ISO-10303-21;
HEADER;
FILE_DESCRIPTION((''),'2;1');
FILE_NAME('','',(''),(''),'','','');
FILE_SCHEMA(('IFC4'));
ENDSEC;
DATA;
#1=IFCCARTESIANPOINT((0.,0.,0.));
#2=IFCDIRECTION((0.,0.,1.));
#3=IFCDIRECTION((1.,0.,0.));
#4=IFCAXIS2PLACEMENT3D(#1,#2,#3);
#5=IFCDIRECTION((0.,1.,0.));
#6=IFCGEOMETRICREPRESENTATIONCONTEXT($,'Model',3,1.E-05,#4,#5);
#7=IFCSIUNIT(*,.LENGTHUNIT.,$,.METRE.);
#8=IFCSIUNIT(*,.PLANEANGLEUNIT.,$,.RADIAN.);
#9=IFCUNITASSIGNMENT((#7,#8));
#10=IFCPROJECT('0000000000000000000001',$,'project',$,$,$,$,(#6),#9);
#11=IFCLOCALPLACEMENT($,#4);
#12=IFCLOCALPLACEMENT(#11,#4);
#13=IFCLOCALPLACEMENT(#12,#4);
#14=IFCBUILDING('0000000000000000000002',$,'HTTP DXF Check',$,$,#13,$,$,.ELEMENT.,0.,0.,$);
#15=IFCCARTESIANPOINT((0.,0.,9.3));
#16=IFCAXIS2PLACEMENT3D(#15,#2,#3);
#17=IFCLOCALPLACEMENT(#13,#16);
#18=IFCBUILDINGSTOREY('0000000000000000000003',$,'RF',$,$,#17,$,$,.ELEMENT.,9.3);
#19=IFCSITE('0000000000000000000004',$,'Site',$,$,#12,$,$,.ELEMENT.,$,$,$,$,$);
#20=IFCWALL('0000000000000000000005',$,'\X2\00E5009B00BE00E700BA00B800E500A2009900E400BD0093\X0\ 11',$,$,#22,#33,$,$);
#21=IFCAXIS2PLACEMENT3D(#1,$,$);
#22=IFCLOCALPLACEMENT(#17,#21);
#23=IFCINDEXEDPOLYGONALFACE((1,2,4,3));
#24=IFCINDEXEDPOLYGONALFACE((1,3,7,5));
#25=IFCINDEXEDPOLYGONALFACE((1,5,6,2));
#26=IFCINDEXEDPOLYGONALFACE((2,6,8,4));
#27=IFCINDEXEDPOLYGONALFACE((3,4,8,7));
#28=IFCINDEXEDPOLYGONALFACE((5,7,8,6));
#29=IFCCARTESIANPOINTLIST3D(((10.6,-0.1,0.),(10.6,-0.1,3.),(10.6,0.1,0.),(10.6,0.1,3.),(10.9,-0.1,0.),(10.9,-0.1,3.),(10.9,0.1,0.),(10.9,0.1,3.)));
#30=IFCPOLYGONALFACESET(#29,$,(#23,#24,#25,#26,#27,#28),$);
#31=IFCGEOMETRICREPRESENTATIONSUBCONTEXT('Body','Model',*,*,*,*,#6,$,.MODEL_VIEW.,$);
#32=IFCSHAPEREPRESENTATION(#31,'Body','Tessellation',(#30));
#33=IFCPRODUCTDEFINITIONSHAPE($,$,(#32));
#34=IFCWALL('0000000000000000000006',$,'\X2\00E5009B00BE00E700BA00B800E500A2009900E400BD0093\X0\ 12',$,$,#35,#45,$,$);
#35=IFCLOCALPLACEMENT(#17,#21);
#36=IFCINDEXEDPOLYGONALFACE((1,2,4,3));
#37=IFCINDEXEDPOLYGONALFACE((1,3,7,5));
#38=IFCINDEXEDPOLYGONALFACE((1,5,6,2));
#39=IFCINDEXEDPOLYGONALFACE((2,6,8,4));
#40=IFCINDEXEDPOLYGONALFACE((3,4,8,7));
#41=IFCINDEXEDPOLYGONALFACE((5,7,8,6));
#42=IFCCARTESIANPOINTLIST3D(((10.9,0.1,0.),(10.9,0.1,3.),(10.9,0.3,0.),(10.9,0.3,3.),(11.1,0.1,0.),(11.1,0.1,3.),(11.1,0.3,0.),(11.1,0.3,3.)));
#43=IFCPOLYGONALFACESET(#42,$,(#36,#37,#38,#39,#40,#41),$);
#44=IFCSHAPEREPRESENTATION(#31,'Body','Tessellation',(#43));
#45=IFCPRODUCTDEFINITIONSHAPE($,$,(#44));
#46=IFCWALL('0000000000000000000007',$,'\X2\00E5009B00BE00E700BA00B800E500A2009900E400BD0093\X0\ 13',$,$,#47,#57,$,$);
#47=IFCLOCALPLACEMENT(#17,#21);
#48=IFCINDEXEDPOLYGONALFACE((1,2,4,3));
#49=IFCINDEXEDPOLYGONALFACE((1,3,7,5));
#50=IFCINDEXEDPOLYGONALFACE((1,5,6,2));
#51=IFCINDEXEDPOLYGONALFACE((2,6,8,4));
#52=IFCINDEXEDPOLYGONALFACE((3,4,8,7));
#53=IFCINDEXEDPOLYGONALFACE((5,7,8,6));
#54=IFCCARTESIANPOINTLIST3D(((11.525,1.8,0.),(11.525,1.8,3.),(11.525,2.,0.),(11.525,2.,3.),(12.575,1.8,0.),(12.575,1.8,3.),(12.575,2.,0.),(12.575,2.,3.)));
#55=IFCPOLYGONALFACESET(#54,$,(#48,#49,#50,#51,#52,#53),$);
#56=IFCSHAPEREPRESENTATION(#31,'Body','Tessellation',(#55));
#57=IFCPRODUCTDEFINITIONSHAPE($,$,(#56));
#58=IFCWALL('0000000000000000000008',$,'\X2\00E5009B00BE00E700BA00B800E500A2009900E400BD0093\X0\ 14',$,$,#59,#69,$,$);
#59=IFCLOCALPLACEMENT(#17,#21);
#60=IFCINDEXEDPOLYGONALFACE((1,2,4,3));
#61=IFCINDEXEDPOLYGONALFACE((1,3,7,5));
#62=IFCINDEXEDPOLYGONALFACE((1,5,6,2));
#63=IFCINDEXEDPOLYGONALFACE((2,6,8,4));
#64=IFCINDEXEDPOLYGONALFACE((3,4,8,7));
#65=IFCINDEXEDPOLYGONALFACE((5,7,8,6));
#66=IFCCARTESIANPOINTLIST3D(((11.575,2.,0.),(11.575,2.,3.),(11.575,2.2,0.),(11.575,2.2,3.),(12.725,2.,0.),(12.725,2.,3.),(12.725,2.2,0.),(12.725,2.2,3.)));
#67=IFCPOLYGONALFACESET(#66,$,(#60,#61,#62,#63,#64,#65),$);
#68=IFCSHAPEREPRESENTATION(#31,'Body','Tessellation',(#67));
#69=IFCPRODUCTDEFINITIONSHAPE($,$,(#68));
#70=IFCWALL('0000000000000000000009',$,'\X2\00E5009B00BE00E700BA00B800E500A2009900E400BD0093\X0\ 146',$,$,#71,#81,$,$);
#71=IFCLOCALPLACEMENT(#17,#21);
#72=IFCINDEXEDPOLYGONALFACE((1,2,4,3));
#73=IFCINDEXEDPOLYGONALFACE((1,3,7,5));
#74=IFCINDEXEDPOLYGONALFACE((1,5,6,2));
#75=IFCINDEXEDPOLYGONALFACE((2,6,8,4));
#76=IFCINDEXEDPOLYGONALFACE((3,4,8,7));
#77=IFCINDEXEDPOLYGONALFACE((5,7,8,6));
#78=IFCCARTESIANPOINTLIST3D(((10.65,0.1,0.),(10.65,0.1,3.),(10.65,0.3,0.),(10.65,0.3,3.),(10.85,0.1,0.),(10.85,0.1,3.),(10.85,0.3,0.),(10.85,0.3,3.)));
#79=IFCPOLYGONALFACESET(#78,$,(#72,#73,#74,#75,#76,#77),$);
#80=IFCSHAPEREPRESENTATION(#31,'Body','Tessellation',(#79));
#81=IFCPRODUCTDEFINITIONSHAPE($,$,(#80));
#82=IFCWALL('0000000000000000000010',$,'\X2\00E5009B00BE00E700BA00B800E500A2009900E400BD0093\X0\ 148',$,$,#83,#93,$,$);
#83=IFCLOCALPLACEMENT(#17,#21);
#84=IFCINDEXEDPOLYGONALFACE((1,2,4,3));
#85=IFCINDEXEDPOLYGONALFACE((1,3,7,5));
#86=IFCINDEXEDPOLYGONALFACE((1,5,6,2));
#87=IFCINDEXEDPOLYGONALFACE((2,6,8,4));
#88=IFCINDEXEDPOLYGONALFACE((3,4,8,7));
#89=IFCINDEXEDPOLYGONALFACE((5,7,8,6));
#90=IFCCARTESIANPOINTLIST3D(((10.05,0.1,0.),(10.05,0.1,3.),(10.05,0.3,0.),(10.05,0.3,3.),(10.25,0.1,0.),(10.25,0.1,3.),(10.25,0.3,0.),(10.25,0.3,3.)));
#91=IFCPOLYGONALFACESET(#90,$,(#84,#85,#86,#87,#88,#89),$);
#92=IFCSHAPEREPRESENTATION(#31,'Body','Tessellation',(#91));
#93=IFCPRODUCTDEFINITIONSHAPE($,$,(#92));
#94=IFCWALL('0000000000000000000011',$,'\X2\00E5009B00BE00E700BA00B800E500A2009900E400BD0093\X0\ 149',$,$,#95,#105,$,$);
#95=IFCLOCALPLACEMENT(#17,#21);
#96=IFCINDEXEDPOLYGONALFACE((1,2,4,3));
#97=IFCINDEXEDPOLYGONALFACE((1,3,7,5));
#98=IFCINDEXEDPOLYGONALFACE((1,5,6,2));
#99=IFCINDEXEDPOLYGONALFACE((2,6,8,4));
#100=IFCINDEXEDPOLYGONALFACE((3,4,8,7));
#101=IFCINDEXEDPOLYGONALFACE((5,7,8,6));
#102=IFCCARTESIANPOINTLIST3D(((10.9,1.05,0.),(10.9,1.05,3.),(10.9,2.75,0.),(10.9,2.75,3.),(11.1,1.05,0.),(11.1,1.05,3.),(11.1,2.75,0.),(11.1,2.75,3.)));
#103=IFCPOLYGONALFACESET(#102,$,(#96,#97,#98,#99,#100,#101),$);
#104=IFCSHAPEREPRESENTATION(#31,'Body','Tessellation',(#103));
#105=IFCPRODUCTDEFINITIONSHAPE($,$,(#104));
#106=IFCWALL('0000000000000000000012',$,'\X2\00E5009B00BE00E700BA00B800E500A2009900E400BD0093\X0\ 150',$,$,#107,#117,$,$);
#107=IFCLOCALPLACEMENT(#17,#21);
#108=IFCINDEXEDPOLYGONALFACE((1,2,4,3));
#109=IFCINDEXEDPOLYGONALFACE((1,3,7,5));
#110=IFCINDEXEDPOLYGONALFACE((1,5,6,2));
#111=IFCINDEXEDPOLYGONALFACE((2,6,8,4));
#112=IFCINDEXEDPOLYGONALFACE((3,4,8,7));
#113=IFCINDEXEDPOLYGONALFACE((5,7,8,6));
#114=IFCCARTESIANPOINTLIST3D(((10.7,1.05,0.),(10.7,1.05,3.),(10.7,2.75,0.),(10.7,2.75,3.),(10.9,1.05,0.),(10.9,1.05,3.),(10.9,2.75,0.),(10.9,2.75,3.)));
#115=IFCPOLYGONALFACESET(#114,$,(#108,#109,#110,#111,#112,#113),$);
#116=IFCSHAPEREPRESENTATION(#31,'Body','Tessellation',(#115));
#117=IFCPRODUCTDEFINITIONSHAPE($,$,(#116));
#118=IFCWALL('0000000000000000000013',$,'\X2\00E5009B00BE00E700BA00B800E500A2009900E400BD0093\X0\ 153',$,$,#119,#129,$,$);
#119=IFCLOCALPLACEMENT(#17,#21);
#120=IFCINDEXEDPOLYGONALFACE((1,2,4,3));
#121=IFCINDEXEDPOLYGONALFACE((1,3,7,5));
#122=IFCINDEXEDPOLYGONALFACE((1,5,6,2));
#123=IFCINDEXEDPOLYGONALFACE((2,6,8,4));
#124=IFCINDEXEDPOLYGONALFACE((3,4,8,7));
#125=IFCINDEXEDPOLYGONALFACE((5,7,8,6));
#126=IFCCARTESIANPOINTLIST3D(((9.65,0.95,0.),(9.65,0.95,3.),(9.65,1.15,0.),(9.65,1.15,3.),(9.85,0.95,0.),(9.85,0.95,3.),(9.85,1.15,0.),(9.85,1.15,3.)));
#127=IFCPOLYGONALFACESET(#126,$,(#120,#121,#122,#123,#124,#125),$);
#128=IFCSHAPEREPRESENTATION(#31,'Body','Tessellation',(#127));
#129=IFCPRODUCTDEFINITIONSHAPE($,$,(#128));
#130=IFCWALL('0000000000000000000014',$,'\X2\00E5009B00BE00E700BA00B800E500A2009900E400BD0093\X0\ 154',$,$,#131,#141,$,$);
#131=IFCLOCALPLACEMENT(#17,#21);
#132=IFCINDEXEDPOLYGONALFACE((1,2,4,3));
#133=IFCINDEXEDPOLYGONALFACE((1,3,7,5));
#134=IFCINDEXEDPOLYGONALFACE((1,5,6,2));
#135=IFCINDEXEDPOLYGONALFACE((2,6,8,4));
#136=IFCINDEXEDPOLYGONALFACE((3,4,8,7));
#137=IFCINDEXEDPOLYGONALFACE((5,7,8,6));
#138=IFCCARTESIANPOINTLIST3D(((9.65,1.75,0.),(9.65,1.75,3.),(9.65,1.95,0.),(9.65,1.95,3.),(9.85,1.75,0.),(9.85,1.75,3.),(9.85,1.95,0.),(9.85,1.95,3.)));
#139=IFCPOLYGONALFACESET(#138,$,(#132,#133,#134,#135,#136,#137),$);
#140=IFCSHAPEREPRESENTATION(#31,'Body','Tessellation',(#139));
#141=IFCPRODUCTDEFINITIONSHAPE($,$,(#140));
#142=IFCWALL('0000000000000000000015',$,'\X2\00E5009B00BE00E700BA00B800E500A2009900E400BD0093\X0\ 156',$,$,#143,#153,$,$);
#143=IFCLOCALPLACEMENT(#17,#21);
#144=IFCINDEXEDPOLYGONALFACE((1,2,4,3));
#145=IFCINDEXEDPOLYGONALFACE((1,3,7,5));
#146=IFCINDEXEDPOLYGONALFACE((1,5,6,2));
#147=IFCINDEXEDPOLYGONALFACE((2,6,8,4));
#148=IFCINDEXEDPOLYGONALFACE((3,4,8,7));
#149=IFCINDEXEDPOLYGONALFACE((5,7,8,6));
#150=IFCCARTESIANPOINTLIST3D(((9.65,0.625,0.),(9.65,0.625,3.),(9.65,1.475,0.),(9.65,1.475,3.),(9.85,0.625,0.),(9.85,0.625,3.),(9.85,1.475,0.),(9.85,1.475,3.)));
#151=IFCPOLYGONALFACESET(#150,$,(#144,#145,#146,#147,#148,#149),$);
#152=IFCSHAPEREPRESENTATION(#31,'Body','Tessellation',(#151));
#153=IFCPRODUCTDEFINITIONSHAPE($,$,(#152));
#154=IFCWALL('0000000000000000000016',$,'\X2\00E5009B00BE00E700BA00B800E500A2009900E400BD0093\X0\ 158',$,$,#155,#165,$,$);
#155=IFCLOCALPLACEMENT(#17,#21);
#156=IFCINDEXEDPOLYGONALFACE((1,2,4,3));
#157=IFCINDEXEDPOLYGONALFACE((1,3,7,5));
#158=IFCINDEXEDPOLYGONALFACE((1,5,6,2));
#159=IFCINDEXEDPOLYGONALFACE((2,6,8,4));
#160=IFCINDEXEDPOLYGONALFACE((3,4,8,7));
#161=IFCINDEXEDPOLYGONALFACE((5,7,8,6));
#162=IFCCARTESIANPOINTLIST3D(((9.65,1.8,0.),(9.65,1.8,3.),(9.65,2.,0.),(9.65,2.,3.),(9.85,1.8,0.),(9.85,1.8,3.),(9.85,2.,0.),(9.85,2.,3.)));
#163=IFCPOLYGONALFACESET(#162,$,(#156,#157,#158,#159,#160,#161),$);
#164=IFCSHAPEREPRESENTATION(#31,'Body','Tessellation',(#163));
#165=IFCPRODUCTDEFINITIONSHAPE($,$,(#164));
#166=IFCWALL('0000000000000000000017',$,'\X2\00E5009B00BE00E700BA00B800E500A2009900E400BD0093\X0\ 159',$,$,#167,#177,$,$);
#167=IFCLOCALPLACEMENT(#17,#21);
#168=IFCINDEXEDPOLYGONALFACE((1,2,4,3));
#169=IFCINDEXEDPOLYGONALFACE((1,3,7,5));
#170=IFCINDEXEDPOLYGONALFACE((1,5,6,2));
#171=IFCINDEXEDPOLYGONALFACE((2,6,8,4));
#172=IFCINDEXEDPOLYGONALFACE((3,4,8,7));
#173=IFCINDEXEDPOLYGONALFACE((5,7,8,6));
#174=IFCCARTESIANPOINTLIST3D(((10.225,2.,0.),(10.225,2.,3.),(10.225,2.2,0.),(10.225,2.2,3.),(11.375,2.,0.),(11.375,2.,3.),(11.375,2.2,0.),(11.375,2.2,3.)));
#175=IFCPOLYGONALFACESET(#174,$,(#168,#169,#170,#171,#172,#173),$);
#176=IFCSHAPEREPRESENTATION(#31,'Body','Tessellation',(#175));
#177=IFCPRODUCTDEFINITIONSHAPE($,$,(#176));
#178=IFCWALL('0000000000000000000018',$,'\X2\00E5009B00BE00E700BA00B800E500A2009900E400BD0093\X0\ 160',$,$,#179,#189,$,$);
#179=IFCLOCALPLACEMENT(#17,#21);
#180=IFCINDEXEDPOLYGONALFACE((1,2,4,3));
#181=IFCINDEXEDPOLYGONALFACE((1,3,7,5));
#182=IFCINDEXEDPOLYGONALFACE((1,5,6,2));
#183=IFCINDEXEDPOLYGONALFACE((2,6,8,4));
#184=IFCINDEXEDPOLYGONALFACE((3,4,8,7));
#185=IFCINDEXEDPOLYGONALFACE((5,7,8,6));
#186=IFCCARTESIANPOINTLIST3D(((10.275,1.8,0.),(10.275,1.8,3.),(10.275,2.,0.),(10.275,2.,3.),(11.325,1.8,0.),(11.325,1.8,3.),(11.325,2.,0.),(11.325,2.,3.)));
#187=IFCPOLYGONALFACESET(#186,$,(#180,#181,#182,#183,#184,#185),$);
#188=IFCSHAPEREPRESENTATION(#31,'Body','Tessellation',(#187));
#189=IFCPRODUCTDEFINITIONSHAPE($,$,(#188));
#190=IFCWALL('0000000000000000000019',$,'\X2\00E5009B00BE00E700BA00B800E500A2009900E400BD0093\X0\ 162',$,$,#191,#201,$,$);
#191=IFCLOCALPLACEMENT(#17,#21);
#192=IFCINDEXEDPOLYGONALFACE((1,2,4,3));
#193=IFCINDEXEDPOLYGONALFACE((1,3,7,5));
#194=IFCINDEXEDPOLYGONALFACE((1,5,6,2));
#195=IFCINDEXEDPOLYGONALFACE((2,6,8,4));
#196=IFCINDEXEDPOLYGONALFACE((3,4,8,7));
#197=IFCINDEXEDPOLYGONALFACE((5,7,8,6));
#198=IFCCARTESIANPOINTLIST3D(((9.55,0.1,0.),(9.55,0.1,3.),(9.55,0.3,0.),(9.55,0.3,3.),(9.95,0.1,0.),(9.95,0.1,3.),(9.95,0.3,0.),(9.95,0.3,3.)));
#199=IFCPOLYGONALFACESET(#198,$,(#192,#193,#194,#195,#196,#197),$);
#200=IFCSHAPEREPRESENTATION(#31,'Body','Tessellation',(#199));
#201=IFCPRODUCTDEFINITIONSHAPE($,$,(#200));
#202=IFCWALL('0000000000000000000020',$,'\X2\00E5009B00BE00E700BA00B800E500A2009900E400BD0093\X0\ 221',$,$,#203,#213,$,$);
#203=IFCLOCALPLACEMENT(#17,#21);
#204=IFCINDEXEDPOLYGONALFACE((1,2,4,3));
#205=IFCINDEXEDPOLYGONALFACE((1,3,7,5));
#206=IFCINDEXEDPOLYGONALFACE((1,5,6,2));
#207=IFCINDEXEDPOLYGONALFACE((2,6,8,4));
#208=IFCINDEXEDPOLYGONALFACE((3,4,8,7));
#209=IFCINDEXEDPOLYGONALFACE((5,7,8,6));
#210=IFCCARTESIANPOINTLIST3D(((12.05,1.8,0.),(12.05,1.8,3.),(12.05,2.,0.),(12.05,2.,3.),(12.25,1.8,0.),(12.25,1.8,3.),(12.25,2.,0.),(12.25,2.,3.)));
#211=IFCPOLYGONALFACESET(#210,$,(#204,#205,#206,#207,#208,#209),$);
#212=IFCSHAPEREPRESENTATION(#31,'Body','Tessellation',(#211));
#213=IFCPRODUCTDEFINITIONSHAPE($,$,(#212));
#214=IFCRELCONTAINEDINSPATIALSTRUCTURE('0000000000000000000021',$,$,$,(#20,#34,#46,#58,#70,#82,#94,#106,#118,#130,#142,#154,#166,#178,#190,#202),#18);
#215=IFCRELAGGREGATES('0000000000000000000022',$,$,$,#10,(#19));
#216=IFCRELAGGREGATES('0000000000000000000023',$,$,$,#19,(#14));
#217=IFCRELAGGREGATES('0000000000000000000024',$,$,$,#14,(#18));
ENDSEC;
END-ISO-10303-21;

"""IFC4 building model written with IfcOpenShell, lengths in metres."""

from ifc_helpers import new_model, si_unit, direction, frame, frame_2d, origin_with_axes, place, context, subcontext, project, spatial, rectangle, extrude, element, save


model = new_model("IFC4")

# Units and contexts
model_context = context("Model", 3, precision=1e-05, world=origin_with_axes(), true_north=direction((0.0, 1.0, 0.0)))
body_context = subcontext(model_context, "Body", "Model", "MODEL_VIEW")
ifc_project = project(units=[si_unit("LENGTHUNIT", "METRE"), si_unit("PLANEANGLEUNIT", "RADIAN")], contexts=[model_context])

# Site, building, storey
placement = place(None, origin_with_axes())
site_placement = place(placement, origin_with_axes())
site = spatial("IfcSite", under=ifc_project, at=site_placement, Name="Site", CompositionType="ELEMENT")
building_placement = place(site_placement, origin_with_axes())
building = spatial("IfcBuilding", under=site, at=building_placement, Name="HTTP DXF Check", CompositionType="ELEMENT", ElevationOfRefHeight=0.0, ElevationOfTerrain=0.0)
storey_placement = place(building_placement, frame((0.0, 0.0, 9.3), z_axis=(0.0, 0.0, 1.0), x_axis=(1.0, 0.0, 0.0)))
storey = spatial("IfcBuildingStorey", under=building, at=storey_placement, Name="RF", CompositionType="ELEMENT", Elevation=9.3)

# Walls
wall_1_placement = place(storey_placement, frame((10.75, 0.0, 0.0), z_axis=(0.0, 0.0, 1.0), x_axis=(1.0, 0.0, 0.0)))
element("IfcWall", 1, at=wall_1_placement, inside=storey, Name="å\u009b¾çº¸å¢\u0099ä½\u0093 11", context=body_context, shape_type="SweptSolid", body=[
    extrude(rectangle(XDim=0.3, YDim=0.2, at=frame_2d((0.0, 0.0), x_axis=(1.0, 0.0, 0.0))), frame((0.0, 0.0, 0.0), z_axis=(0.0, 0.0, 1.0)), (0.0, 0.0, 1.0), 3.0),
])
wall_2_placement = place(storey_placement, frame((11.0, 0.2, 0.0), z_axis=(0.0, 0.0, 1.0), x_axis=(1.0, 0.0, 0.0)))
element("IfcWall", 2, at=wall_2_placement, inside=storey, Name="å\u009b¾çº¸å¢\u0099ä½\u0093 12", context=body_context, shape_type="SweptSolid", body=[
    extrude(rectangle(XDim=0.2, YDim=0.2, at=frame_2d((0.0, 0.0), x_axis=(1.0, 0.0, 0.0))), frame((0.0, 0.0, 0.0), z_axis=(0.0, 0.0, 1.0)), (0.0, 0.0, 1.0), 3.0),
])
wall_3_placement = place(storey_placement, frame((12.05, 1.9, 0.0), z_axis=(0.0, 0.0, 1.0), x_axis=(-1.0, 0.0, 0.0)))
element("IfcWall", 3, at=wall_3_placement, inside=storey, Name="å\u009b¾çº¸å¢\u0099ä½\u0093 13", context=body_context, shape_type="SweptSolid", body=[
    extrude(rectangle(XDim=1.05, YDim=0.2, at=frame_2d((0.0, 0.0), x_axis=(1.0, 0.0, 0.0))), frame((0.0, 0.0, 0.0), z_axis=(0.0, 0.0, 1.0)), (0.0, 0.0, 1.0), 3.0),
])
wall_4_placement = place(storey_placement, frame((12.15, 2.1, 0.0), z_axis=(0.0, 0.0, 1.0), x_axis=(-1.0, 0.0, 0.0)))
element("IfcWall", 4, at=wall_4_placement, inside=storey, Name="å\u009b¾çº¸å¢\u0099ä½\u0093 14", context=body_context, shape_type="SweptSolid", body=[
    extrude(rectangle(XDim=1.15, YDim=0.2, at=frame_2d((0.0, 0.0), x_axis=(1.0, 0.0, 0.0))), frame((0.0, 0.0, 0.0), z_axis=(0.0, 0.0, 1.0)), (0.0, 0.0, 1.0), 3.0),
])
for number, where, z_axis, x_axis, name in (
    (5, (10.75, 0.2, 0.0), (0.0, 0.0, 1.0), (1.0, 0.0, 0.0), "å\u009b¾çº¸å¢\u0099ä½\u0093 146"),
    (6, (10.15, 0.2, 0.0), (0.0, 0.0, 1.0), (0.0, -1.0, 0.0), "å\u009b¾çº¸å¢\u0099ä½\u0093 148"),
):
    element("IfcWall", number, at=place(storey_placement, frame(where, z_axis=z_axis, x_axis=x_axis)), inside=storey, Name=name, context=body_context, shape_type="SweptSolid", body=[
        extrude(rectangle(XDim=0.2, YDim=0.2, at=frame_2d((0.0, 0.0), x_axis=(1.0, 0.0, 0.0))), frame((0.0, 0.0, 0.0), z_axis=(0.0, 0.0, 1.0)), (0.0, 0.0, 1.0), 3.0),
    ])
for number, where, z_axis, x_axis, name in (
    (7, (11.0, 1.9, 0.0), (0.0, 0.0, 1.0), (0.0, -1.0, 0.0), "å\u009b¾çº¸å¢\u0099ä½\u0093 149"),
    (8, (10.8, 1.9, 0.0), (0.0, 0.0, 1.0), (0.0, -1.0, 0.0), "å\u009b¾çº¸å¢\u0099ä½\u0093 150"),
):
    element("IfcWall", number, at=place(storey_placement, frame(where, z_axis=z_axis, x_axis=x_axis)), inside=storey, Name=name, context=body_context, shape_type="SweptSolid", body=[
        extrude(rectangle(XDim=1.7, YDim=0.2, at=frame_2d((0.0, 0.0), x_axis=(1.0, 0.0, 0.0))), frame((0.0, 0.0, 0.0), z_axis=(0.0, 0.0, 1.0)), (0.0, 0.0, 1.0), 3.0),
    ])
for number, where, z_axis, x_axis, name in (
    (9, (9.75, 1.05, 0.0), (0.0, 0.0, 1.0), (-1.0, 0.0, 0.0), "å\u009b¾çº¸å¢\u0099ä½\u0093 153"),
    (10, (9.75, 1.85, 0.0), (0.0, 0.0, 1.0), (-1.0, 0.0, 0.0), "å\u009b¾çº¸å¢\u0099ä½\u0093 154"),
):
    element("IfcWall", number, at=place(storey_placement, frame(where, z_axis=z_axis, x_axis=x_axis)), inside=storey, Name=name, context=body_context, shape_type="SweptSolid", body=[
        extrude(rectangle(XDim=0.2, YDim=0.2, at=frame_2d((0.0, 0.0), x_axis=(1.0, 0.0, 0.0))), frame((0.0, 0.0, 0.0), z_axis=(0.0, 0.0, 1.0)), (0.0, 0.0, 1.0), 3.0),
    ])
wall_5_placement = place(storey_placement, frame((9.75, 1.05, 0.0), z_axis=(0.0, 0.0, 1.0), x_axis=(0.0, -1.0, 0.0)))
element("IfcWall", 11, at=wall_5_placement, inside=storey, Name="å\u009b¾çº¸å¢\u0099ä½\u0093 156", context=body_context, shape_type="SweptSolid", body=[
    extrude(rectangle(XDim=0.85, YDim=0.2, at=frame_2d((0.0, 0.0), x_axis=(1.0, 0.0, 0.0))), frame((0.0, 0.0, 0.0), z_axis=(0.0, 0.0, 1.0)), (0.0, 0.0, 1.0), 3.0),
])
wall_6_placement = place(storey_placement, frame((9.75, 1.9, 0.0), z_axis=(0.0, 0.0, 1.0), x_axis=(0.0, -1.0, 0.0)))
element("IfcWall", 12, at=wall_6_placement, inside=storey, Name="å\u009b¾çº¸å¢\u0099ä½\u0093 158", context=body_context, shape_type="SweptSolid", body=[
    extrude(rectangle(XDim=0.2, YDim=0.2, at=frame_2d((0.0, 0.0), x_axis=(1.0, 0.0, 0.0))), frame((0.0, 0.0, 0.0), z_axis=(0.0, 0.0, 1.0)), (0.0, 0.0, 1.0), 3.0),
])
wall_7_placement = place(storey_placement, frame((10.8, 2.1, 0.0), z_axis=(0.0, 0.0, 1.0), x_axis=(-1.0, 0.0, 0.0)))
element("IfcWall", 13, at=wall_7_placement, inside=storey, Name="å\u009b¾çº¸å¢\u0099ä½\u0093 159", context=body_context, shape_type="SweptSolid", body=[
    extrude(rectangle(XDim=1.15, YDim=0.2, at=frame_2d((0.0, 0.0), x_axis=(1.0, 0.0, 0.0))), frame((0.0, 0.0, 0.0), z_axis=(0.0, 0.0, 1.0)), (0.0, 0.0, 1.0), 3.0),
])
wall_8_placement = place(storey_placement, frame((10.8, 1.9, 0.0), z_axis=(0.0, 0.0, 1.0), x_axis=(-1.0, 0.0, 0.0)))
element("IfcWall", 14, at=wall_8_placement, inside=storey, Name="å\u009b¾çº¸å¢\u0099ä½\u0093 160", context=body_context, shape_type="SweptSolid", body=[
    extrude(rectangle(XDim=1.05, YDim=0.2, at=frame_2d((0.0, 0.0), x_axis=(1.0, 0.0, 0.0))), frame((0.0, 0.0, 0.0), z_axis=(0.0, 0.0, 1.0)), (0.0, 0.0, 1.0), 3.0),
])
wall_9_placement = place(storey_placement, frame((9.75, 0.2, 0.0), z_axis=(0.0, 0.0, 1.0), x_axis=(1.0, 0.0, 0.0)))
element("IfcWall", 15, at=wall_9_placement, inside=storey, Name="å\u009b¾çº¸å¢\u0099ä½\u0093 162", context=body_context, shape_type="SweptSolid", body=[
    extrude(rectangle(XDim=0.4, YDim=0.2, at=frame_2d((0.0, 0.0), x_axis=(1.0, 0.0, 0.0))), frame((0.0, 0.0, 0.0), z_axis=(0.0, 0.0, 1.0)), (0.0, 0.0, 1.0), 3.0),
])
for number, where, z_axis, x_axis, name in (
    (16, (12.15, 1.9, 0.0), (0.0, 0.0, 1.0), (0.0, 1.0, 0.0), "å\u009b¾çº¸å¢\u0099ä½\u0093 221"),
):
    element("IfcWall", number, at=place(storey_placement, frame(where, z_axis=z_axis, x_axis=x_axis)), inside=storey, Name=name, context=body_context, shape_type="SweptSolid", body=[
        extrude(rectangle(XDim=0.2, YDim=0.2, at=frame_2d((0.0, 0.0), x_axis=(1.0, 0.0, 0.0))), frame((0.0, 0.0, 0.0), z_axis=(0.0, 0.0, 1.0)), (0.0, 0.0, 1.0), 3.0),
    ])

save(model, "model.ifc")
